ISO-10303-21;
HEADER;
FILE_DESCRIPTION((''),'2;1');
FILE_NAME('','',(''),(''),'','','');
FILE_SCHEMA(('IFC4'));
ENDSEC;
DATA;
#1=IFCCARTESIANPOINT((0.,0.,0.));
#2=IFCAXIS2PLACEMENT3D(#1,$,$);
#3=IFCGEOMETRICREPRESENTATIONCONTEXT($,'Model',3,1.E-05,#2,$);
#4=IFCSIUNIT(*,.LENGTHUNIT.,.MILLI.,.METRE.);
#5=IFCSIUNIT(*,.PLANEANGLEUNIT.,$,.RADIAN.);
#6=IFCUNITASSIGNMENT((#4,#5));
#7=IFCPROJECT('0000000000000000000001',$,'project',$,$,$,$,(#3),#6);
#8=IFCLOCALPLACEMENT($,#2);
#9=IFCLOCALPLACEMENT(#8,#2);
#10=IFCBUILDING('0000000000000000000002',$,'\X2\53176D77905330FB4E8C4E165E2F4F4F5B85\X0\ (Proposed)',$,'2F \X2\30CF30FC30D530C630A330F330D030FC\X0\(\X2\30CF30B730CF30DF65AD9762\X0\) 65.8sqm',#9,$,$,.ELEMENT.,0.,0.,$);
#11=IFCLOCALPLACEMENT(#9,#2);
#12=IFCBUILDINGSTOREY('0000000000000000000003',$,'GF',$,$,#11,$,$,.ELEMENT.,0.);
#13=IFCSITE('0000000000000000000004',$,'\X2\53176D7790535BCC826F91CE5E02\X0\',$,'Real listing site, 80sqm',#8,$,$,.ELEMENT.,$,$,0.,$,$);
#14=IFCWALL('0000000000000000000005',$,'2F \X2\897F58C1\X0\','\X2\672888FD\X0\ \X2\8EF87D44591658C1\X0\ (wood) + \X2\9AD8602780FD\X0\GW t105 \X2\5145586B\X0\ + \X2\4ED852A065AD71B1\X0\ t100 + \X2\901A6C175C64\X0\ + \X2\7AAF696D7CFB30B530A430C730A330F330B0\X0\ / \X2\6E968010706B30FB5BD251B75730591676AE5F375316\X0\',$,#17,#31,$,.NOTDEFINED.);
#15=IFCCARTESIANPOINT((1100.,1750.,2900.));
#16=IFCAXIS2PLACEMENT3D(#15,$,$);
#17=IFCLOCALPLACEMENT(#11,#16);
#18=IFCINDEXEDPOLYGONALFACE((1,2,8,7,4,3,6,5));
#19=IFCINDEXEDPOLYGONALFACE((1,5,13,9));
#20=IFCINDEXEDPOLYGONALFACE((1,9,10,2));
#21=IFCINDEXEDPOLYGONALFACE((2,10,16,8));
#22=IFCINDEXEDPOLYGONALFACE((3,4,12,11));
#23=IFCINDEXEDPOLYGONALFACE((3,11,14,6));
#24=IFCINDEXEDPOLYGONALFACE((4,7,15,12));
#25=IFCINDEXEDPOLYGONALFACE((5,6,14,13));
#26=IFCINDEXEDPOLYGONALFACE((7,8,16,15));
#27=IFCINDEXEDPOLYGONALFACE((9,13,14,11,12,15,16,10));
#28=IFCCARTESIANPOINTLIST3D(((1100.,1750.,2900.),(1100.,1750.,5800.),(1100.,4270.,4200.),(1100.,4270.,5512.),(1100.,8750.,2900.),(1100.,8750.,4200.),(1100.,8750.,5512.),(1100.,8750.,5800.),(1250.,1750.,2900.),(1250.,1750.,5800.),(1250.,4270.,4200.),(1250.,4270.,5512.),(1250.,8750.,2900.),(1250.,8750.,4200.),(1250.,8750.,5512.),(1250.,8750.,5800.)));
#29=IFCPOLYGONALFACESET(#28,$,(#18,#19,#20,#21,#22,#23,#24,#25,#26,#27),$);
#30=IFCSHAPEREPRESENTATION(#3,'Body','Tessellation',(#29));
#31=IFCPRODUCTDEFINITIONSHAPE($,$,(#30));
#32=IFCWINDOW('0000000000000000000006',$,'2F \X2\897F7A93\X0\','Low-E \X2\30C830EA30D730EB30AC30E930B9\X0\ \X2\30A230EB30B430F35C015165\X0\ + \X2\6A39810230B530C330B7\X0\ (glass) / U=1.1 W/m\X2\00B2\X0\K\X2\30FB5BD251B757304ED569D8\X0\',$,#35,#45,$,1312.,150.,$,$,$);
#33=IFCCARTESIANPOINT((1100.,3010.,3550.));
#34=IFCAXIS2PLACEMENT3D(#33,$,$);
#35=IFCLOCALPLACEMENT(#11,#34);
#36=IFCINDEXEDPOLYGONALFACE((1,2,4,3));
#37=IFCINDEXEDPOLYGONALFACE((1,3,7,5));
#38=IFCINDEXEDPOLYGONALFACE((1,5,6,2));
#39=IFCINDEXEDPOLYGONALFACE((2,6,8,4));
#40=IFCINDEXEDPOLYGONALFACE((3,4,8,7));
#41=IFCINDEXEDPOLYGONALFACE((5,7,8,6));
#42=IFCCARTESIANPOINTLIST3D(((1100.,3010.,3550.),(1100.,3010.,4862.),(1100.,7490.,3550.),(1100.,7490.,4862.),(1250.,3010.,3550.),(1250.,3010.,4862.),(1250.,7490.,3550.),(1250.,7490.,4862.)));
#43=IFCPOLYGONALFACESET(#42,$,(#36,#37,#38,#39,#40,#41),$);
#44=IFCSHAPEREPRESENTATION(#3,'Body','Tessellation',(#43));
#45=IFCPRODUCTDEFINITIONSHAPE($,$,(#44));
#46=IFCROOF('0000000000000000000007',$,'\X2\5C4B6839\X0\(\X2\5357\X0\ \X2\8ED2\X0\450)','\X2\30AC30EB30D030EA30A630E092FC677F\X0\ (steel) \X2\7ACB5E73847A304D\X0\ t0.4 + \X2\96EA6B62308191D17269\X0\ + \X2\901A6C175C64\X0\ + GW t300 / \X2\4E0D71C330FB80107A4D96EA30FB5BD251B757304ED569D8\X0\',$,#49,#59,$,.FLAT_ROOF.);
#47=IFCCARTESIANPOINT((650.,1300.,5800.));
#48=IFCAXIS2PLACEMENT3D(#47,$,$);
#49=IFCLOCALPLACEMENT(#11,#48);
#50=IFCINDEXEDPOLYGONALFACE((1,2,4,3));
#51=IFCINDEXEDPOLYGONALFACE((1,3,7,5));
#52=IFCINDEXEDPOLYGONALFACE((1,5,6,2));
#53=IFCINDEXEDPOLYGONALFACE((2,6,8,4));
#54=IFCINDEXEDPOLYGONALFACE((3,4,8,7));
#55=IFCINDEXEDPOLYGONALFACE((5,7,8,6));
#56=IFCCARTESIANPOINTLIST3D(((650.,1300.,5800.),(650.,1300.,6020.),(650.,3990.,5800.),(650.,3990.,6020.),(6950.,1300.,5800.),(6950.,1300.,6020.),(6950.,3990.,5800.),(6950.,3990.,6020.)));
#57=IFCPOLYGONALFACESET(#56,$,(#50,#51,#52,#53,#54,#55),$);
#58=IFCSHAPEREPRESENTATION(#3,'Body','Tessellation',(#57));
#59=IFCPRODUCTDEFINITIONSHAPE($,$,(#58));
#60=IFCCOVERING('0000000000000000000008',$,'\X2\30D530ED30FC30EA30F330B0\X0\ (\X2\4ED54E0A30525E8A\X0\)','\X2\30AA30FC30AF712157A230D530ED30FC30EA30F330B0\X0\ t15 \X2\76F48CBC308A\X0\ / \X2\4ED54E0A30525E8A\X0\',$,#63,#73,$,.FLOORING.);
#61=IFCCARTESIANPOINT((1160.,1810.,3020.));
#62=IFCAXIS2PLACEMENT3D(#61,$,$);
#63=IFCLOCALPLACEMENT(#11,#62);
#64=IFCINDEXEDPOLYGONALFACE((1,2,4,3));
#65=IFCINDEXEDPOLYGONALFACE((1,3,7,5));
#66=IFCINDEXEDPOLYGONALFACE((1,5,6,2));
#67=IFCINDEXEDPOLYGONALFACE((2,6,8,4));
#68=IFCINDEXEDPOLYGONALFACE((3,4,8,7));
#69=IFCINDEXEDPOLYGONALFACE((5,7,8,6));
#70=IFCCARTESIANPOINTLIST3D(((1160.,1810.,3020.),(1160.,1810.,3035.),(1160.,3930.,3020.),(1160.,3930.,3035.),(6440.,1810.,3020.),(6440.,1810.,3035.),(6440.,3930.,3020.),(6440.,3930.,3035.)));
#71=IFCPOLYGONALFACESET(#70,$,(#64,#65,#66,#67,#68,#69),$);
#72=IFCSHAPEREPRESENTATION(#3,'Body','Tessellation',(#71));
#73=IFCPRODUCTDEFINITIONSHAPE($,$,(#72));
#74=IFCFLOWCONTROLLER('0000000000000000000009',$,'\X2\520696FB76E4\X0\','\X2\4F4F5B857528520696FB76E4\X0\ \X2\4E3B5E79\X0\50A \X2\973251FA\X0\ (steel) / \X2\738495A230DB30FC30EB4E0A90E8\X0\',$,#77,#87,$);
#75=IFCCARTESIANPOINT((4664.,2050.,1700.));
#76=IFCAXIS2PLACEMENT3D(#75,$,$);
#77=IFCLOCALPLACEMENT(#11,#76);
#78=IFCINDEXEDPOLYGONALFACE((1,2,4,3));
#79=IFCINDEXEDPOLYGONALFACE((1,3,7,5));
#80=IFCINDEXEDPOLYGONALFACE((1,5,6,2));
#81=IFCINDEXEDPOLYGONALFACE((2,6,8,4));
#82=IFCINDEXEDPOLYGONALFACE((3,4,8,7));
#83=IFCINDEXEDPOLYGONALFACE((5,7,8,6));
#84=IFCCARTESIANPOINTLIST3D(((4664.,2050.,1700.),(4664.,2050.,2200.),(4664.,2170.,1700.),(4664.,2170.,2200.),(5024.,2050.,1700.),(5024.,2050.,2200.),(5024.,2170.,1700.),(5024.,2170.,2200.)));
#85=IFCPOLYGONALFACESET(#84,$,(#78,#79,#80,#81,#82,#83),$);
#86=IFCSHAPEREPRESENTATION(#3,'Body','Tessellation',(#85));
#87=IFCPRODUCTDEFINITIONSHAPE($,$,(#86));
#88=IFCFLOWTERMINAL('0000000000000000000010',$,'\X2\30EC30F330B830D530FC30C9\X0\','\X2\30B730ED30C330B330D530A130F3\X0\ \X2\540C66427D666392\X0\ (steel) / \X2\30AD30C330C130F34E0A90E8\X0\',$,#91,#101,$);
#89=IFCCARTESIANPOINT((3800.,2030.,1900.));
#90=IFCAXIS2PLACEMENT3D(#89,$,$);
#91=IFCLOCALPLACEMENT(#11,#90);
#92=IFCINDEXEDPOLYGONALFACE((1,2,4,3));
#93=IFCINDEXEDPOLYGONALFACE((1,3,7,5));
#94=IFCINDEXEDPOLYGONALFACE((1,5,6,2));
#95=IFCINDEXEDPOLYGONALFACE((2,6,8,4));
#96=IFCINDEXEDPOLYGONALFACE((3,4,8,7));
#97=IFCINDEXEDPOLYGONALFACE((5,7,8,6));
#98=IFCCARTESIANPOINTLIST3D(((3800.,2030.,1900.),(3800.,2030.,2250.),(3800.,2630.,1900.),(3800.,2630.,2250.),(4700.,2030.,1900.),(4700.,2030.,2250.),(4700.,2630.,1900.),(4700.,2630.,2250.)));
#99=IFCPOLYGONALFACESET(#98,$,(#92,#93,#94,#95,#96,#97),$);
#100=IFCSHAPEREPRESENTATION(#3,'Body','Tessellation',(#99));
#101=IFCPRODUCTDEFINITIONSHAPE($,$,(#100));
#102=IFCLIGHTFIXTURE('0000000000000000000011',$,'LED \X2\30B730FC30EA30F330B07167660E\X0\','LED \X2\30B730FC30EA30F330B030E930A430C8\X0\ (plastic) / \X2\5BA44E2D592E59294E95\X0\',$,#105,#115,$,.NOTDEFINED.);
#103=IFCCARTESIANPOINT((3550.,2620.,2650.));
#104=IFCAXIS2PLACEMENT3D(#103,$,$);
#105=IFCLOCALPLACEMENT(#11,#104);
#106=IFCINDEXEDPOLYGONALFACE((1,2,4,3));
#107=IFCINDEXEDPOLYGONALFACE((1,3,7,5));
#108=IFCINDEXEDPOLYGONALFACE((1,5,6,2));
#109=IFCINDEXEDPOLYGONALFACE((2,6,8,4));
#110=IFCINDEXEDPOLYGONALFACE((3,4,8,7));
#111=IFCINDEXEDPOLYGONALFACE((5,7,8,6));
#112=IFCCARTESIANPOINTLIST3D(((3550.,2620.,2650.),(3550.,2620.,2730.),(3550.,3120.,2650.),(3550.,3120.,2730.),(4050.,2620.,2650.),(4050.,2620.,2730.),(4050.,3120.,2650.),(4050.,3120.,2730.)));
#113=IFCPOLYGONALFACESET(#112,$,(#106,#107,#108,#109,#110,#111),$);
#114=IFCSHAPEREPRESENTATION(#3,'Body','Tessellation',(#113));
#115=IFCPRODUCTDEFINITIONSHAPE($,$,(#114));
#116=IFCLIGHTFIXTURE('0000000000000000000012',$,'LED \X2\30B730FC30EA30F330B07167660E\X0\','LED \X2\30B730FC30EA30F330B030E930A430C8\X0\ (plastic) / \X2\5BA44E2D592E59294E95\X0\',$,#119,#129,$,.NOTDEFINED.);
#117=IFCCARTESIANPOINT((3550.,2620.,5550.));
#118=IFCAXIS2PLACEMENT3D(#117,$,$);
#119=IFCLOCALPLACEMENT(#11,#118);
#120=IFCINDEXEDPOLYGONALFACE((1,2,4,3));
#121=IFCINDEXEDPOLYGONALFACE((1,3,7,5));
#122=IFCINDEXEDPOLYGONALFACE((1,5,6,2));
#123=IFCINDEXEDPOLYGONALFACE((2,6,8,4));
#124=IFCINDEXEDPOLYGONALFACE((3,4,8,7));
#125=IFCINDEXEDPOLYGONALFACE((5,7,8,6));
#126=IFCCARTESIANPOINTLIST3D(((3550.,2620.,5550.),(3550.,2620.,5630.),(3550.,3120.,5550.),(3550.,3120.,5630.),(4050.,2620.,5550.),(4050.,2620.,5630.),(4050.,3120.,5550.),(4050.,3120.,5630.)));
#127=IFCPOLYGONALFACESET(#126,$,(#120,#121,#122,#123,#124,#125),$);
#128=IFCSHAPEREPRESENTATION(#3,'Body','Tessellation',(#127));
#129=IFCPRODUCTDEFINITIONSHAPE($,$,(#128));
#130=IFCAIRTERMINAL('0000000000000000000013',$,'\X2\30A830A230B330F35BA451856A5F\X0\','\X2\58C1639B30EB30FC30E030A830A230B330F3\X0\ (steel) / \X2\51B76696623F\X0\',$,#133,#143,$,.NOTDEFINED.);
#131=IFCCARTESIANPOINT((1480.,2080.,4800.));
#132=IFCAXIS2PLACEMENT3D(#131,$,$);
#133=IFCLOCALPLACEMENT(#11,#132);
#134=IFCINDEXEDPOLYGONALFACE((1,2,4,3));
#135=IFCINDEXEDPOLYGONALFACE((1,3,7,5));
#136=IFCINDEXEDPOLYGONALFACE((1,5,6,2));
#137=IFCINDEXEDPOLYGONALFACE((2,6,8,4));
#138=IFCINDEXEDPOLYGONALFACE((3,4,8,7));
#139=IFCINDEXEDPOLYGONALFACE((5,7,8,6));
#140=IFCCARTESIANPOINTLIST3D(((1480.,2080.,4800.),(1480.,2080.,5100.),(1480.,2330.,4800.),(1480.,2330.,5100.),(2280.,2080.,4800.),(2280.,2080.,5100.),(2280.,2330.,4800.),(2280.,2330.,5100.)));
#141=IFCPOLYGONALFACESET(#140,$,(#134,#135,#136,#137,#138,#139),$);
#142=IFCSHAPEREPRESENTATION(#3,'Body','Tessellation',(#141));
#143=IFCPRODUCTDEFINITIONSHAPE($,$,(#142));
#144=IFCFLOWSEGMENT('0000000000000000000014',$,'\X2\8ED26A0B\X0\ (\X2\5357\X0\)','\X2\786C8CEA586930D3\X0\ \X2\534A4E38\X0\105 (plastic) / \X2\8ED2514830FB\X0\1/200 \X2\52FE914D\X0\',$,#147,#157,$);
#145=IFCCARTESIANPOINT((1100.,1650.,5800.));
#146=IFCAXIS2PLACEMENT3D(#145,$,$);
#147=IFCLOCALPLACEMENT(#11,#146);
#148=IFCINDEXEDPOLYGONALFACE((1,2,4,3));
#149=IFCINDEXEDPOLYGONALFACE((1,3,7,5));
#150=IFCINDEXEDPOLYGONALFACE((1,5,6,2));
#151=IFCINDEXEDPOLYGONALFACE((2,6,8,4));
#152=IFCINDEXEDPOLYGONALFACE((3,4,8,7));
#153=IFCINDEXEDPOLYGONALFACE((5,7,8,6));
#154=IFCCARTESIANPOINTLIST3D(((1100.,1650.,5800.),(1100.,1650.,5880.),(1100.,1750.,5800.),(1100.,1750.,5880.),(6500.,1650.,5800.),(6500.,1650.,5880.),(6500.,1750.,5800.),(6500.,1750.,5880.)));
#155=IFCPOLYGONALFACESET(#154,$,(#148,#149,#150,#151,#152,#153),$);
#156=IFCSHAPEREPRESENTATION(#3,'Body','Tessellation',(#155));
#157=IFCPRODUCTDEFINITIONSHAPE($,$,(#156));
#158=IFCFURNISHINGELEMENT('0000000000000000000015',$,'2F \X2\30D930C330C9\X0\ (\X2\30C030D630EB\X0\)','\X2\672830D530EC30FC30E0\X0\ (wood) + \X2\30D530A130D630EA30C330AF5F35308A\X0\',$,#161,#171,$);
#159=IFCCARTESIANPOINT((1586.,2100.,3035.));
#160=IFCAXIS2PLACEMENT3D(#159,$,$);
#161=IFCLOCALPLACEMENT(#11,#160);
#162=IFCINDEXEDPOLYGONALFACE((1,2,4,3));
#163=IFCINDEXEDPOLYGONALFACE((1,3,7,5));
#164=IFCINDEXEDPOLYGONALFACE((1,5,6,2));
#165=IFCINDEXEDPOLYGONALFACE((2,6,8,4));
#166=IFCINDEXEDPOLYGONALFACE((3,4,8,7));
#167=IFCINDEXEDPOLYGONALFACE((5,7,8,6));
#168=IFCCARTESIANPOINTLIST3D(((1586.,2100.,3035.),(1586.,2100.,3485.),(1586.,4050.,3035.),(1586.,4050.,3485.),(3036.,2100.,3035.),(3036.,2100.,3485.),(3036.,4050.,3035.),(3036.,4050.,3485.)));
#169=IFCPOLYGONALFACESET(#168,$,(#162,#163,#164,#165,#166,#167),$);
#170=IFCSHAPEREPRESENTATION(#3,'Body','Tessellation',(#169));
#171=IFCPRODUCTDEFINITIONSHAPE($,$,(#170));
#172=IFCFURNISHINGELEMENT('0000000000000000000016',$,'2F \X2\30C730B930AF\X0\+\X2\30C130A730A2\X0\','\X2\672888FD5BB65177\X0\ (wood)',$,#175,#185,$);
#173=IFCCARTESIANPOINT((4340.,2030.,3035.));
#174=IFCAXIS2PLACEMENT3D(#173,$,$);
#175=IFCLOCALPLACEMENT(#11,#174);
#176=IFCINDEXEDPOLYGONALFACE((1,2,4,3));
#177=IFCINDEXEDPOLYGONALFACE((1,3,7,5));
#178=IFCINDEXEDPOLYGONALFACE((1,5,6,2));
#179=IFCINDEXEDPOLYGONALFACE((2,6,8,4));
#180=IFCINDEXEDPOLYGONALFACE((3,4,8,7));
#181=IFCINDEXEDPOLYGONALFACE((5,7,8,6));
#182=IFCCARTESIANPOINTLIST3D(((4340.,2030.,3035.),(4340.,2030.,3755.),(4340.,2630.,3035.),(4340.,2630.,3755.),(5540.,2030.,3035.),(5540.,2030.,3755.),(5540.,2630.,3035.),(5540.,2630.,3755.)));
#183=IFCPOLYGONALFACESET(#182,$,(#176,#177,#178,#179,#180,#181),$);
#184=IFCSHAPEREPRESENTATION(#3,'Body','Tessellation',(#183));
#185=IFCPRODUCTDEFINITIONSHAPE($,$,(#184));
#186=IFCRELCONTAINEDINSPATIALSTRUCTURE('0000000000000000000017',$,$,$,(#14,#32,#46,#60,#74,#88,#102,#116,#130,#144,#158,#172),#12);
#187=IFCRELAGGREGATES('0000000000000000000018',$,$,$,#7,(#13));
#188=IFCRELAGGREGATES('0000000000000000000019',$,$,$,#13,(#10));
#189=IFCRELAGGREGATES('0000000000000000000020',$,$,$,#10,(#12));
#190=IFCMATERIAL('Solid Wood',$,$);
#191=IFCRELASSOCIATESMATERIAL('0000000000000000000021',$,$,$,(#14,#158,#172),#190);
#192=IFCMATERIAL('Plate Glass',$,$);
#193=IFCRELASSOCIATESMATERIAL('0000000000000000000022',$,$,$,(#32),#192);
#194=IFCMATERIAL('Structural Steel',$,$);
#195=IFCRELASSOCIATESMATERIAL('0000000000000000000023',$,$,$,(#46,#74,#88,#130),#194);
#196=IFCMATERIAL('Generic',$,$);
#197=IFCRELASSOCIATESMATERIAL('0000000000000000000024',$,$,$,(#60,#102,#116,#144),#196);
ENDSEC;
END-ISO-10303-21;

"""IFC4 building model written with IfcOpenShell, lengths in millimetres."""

from ifc_helpers import new_model, si_unit, frame, frame_2d, origin, place, context, project, spatial, rectangle, extrude, material, element, fill, save


model = new_model("IFC4")

# Units and contexts
model_context = context("Model", 3, precision=1e-05, world=origin())
ifc_project = project(units=[si_unit("LENGTHUNIT", "METRE", prefix="MILLI"), si_unit("PLANEANGLEUNIT", "RADIAN")], contexts=[model_context])

# Site, building, storey
site_placement = place(None, origin())
site = spatial("IfcSite", under=ifc_project, at=site_placement, Name="北海道富良野市", ObjectType="Real listing site, 80sqm", CompositionType="ELEMENT", RefElevation=0.0)
building_placement = place(site_placement, origin())
building = spatial("IfcBuilding", under=site, at=building_placement, Name="北海道・二世帯住宅 (Proposed)", ObjectType="2F ハーフティンバー(ハシハミ断面) 65.8sqm", CompositionType="ELEMENT", ElevationOfRefHeight=0.0, ElevationOfTerrain=0.0)
storey_placement = place(building_placement, origin())
storey = spatial("IfcBuildingStorey", under=building, at=storey_placement, Name="GF", CompositionType="ELEMENT", Elevation=0.0)

# Shared definitions
ifc_material_1 = material(Name="Solid Wood")

# Wall, opening, window
ifc_material_2 = material(Name="Plate Glass")
wall_1_placement = place(storey_placement, frame((1100.0, 1750.0, 2900.0)))
wall_1 = element("IfcWall", 1, at=wall_1_placement, inside=storey, material=ifc_material_1, Name="2F 西壁", Description="木製 軸組外壁 (wood) + 高性能GW t105 充填 + 付加断熱 t100 + 通気層 + 窯業系サイディング / 準耐火・寒冷地外皮強化", PredefinedType="NOTDEFINED", context=model_context, shape_type="SweptSolid", body=[
    extrude(rectangle(XDim=150.0, YDim=7000.0, at=frame_2d((75.0, 3500.0))), frame((1100.0, 1750.0, 2900.0)), (0.0, 0.0, 1.0), 2900.0),
])
opening_1_placement = place(storey_placement, frame((1100.0, 3010.0, 3550.0)))
opening_1 = element("IfcOpeningElement", 2, at=opening_1_placement, cuts=wall_1, PredefinedType="NOTDEFINED", context=model_context, shape_type="SweptSolid", body=[
    extrude(rectangle(XDim=150.0, YDim=4480.0, at=frame_2d((75.0, 2240.0))), frame((1100.0, 3010.0, 3550.0)), (0.0, 0.0, 1.0), 1312.0),
])
window_1_placement = place(storey_placement, frame((1100.0, 3010.0, 3550.0)))
window_1 = element("IfcWindow", 3, at=window_1_placement, inside=storey, material=ifc_material_2, Name="2F 西窓", Description="Low-E トリプルガラス アルゴン封入 + 樹脂サッシ (glass) / U=1.1 W/m²K・寒冷地仕様", OverallHeight=1312.0, OverallWidth=150.0, context=model_context, shape_type="SweptSolid", body=[
    extrude(rectangle(XDim=150.0, YDim=4480.0, at=frame_2d((75.0, 2240.0))), frame((1100.0, 3010.0, 3550.0)), (0.0, 0.0, 1.0), 1312.0),
])
fill(opening_1, window_1)

# Roof
ifc_material_3 = material(Name="Structural Steel")
for number, where, name in (
    (4, (650.0, 1300.0, 5800.0), "屋根(南 軒450)"),
):
    element("IfcRoof", number, at=place(storey_placement, frame(where)), inside=storey, material=ifc_material_3, Name=name, Description="ガルバリウム鋼板 (steel) 立平葺き t0.4 + 雪止め金物 + 通気層 + GW t300 / 不燃・耐積雪・寒冷地仕様", PredefinedType="FLAT_ROOF", context=model_context, shape_type="SweptSolid", body=[
        extrude(rectangle(XDim=6300.0, YDim=2690.0, at=frame_2d((3150.0, 1345.0))), frame((650.0, 1300.0, 5800.0)), (0.0, 0.0, 1.0), 220.0),
    ])

# Covering
ifc_material_4 = material(Name="Generic")
covering_placement = place(storey_placement, frame((1160.0, 1810.0, 3020.0)))
element("IfcCovering", 5, at=covering_placement, inside=storey, material=ifc_material_4, Name="フローリング (仕上げ床)", Description="オーク無垢フローリング t15 直貼り / 仕上げ床", PredefinedType="FLOORING", context=model_context, shape_type="SweptSolid", body=[
    extrude(rectangle(XDim=5280.0, YDim=2120.0, at=frame_2d((2640.0, 1060.0))), frame((1160.0, 1810.0, 3020.0)), (0.0, 0.0, 1.0), 15.0),
])

# Flow controller
flow_controller_placement = place(storey_placement, frame((4664.0, 2050.0, 1700.0)))
element("IfcFlowController", 6, at=flow_controller_placement, inside=storey, material=ifc_material_3, Name="分電盤", Description="住宅用分電盤 主幹50A 露出 (steel) / 玄関ホール上部", context=model_context, shape_type="SweptSolid", body=[
    extrude(rectangle(XDim=360.0, YDim=120.0, at=frame_2d((180.0, 60.0))), frame((4664.0, 2050.0, 1700.0)), (0.0, 0.0, 1.0), 500.0),
])

# Flow terminal
flow_terminal_placement = place(storey_placement, frame((3800.0, 2030.0, 1900.0)))
element("IfcFlowTerminal", 7, at=flow_terminal_placement, inside=storey, material=ifc_material_3, Name="レンジフード", Description="シロッコファン 同時給排 (steel) / キッチン上部", context=model_context, shape_type="SweptSolid", body=[
    extrude(rectangle(XDim=900.0, YDim=600.0, at=frame_2d((450.0, 300.0))), frame((3800.0, 2030.0, 1900.0)), (0.0, 0.0, 1.0), 350.0),
])

# Light fixtures
light_fixture_1_placement = place(storey_placement, frame((3550.0, 2620.0, 2650.0)))
element("IfcLightFixture", 8, at=light_fixture_1_placement, inside=storey, material=ifc_material_4, Name="LED シーリング照明", Description="LED シーリングライト (plastic) / 室中央天井", PredefinedType="NOTDEFINED", context=model_context, shape_type="SweptSolid", body=[
    extrude(rectangle(XDim=500.0, YDim=500.0, at=frame_2d((250.0, 250.0))), frame((3550.0, 2620.0, 2650.0)), (0.0, 0.0, 1.0), 80.0),
])
light_fixture_2_placement = place(storey_placement, frame((3550.0, 2620.0, 5550.0)))
element("IfcLightFixture", 9, at=light_fixture_2_placement, inside=storey, material=ifc_material_4, Name="LED シーリング照明", Description="LED シーリングライト (plastic) / 室中央天井", PredefinedType="NOTDEFINED", context=model_context, shape_type="SweptSolid", body=[
    extrude(rectangle(XDim=500.0, YDim=500.0, at=frame_2d((250.0, 250.0))), frame((3550.0, 2620.0, 5550.0)), (0.0, 0.0, 1.0), 80.0),
])

# Air terminal
air_terminal_placement = place(storey_placement, frame((1480.0, 2080.0, 4800.0)))
element("IfcAirTerminal", 10, at=air_terminal_placement, inside=storey, material=ifc_material_3, Name="エアコン室内機", Description="壁掛ルームエアコン (steel) / 冷暖房", PredefinedType="NOTDEFINED", context=model_context, shape_type="SweptSolid", body=[
    extrude(rectangle(XDim=800.0, YDim=250.0, at=frame_2d((400.0, 125.0))), frame((1480.0, 2080.0, 4800.0)), (0.0, 0.0, 1.0), 300.0),
])

# Flow segment
flow_segment_placement = place(storey_placement, frame((1100.0, 1650.0, 5800.0)))
element("IfcFlowSegment", 11, at=flow_segment_placement, inside=storey, material=ifc_material_4, Name="軒樋 (南)", Description="硬質塩ビ 半丸105 (plastic) / 軒先・1/200 勾配", context=model_context, shape_type="SweptSolid", body=[
    extrude(rectangle(XDim=5400.0, YDim=100.0, at=frame_2d((2700.0, 50.0))), frame((1100.0, 1650.0, 5800.0)), (0.0, 0.0, 1.0), 80.0),
])

# Furnishing elements
furnishing_1_placement = place(storey_placement, frame((1586.0, 2100.0, 3035.0)))
element("IfcFurnishingElement", 12, at=furnishing_1_placement, inside=storey, material=ifc_material_1, Name="2F ベッド (ダブル)", Description="木フレーム (wood) + ファブリック張り", context=model_context, shape_type="SweptSolid", body=[
    extrude(rectangle(XDim=1450.0, YDim=1950.0, at=frame_2d((725.0, 975.0))), frame((1586.0, 2100.0, 3035.0)), (0.0, 0.0, 1.0), 450.0),
])
furnishing_2_placement = place(storey_placement, frame((4340.0, 2030.0, 3035.0)))
element("IfcFurnishingElement", 13, at=furnishing_2_placement, inside=storey, material=ifc_material_1, Name="2F デスク+チェア", Description="木製家具 (wood)", context=model_context, shape_type="SweptSolid", body=[
    extrude(rectangle(XDim=1200.0, YDim=600.0, at=frame_2d((600.0, 300.0))), frame((4340.0, 2030.0, 3035.0)), (0.0, 0.0, 1.0), 720.0),
])

save(model, "model.ifc")
